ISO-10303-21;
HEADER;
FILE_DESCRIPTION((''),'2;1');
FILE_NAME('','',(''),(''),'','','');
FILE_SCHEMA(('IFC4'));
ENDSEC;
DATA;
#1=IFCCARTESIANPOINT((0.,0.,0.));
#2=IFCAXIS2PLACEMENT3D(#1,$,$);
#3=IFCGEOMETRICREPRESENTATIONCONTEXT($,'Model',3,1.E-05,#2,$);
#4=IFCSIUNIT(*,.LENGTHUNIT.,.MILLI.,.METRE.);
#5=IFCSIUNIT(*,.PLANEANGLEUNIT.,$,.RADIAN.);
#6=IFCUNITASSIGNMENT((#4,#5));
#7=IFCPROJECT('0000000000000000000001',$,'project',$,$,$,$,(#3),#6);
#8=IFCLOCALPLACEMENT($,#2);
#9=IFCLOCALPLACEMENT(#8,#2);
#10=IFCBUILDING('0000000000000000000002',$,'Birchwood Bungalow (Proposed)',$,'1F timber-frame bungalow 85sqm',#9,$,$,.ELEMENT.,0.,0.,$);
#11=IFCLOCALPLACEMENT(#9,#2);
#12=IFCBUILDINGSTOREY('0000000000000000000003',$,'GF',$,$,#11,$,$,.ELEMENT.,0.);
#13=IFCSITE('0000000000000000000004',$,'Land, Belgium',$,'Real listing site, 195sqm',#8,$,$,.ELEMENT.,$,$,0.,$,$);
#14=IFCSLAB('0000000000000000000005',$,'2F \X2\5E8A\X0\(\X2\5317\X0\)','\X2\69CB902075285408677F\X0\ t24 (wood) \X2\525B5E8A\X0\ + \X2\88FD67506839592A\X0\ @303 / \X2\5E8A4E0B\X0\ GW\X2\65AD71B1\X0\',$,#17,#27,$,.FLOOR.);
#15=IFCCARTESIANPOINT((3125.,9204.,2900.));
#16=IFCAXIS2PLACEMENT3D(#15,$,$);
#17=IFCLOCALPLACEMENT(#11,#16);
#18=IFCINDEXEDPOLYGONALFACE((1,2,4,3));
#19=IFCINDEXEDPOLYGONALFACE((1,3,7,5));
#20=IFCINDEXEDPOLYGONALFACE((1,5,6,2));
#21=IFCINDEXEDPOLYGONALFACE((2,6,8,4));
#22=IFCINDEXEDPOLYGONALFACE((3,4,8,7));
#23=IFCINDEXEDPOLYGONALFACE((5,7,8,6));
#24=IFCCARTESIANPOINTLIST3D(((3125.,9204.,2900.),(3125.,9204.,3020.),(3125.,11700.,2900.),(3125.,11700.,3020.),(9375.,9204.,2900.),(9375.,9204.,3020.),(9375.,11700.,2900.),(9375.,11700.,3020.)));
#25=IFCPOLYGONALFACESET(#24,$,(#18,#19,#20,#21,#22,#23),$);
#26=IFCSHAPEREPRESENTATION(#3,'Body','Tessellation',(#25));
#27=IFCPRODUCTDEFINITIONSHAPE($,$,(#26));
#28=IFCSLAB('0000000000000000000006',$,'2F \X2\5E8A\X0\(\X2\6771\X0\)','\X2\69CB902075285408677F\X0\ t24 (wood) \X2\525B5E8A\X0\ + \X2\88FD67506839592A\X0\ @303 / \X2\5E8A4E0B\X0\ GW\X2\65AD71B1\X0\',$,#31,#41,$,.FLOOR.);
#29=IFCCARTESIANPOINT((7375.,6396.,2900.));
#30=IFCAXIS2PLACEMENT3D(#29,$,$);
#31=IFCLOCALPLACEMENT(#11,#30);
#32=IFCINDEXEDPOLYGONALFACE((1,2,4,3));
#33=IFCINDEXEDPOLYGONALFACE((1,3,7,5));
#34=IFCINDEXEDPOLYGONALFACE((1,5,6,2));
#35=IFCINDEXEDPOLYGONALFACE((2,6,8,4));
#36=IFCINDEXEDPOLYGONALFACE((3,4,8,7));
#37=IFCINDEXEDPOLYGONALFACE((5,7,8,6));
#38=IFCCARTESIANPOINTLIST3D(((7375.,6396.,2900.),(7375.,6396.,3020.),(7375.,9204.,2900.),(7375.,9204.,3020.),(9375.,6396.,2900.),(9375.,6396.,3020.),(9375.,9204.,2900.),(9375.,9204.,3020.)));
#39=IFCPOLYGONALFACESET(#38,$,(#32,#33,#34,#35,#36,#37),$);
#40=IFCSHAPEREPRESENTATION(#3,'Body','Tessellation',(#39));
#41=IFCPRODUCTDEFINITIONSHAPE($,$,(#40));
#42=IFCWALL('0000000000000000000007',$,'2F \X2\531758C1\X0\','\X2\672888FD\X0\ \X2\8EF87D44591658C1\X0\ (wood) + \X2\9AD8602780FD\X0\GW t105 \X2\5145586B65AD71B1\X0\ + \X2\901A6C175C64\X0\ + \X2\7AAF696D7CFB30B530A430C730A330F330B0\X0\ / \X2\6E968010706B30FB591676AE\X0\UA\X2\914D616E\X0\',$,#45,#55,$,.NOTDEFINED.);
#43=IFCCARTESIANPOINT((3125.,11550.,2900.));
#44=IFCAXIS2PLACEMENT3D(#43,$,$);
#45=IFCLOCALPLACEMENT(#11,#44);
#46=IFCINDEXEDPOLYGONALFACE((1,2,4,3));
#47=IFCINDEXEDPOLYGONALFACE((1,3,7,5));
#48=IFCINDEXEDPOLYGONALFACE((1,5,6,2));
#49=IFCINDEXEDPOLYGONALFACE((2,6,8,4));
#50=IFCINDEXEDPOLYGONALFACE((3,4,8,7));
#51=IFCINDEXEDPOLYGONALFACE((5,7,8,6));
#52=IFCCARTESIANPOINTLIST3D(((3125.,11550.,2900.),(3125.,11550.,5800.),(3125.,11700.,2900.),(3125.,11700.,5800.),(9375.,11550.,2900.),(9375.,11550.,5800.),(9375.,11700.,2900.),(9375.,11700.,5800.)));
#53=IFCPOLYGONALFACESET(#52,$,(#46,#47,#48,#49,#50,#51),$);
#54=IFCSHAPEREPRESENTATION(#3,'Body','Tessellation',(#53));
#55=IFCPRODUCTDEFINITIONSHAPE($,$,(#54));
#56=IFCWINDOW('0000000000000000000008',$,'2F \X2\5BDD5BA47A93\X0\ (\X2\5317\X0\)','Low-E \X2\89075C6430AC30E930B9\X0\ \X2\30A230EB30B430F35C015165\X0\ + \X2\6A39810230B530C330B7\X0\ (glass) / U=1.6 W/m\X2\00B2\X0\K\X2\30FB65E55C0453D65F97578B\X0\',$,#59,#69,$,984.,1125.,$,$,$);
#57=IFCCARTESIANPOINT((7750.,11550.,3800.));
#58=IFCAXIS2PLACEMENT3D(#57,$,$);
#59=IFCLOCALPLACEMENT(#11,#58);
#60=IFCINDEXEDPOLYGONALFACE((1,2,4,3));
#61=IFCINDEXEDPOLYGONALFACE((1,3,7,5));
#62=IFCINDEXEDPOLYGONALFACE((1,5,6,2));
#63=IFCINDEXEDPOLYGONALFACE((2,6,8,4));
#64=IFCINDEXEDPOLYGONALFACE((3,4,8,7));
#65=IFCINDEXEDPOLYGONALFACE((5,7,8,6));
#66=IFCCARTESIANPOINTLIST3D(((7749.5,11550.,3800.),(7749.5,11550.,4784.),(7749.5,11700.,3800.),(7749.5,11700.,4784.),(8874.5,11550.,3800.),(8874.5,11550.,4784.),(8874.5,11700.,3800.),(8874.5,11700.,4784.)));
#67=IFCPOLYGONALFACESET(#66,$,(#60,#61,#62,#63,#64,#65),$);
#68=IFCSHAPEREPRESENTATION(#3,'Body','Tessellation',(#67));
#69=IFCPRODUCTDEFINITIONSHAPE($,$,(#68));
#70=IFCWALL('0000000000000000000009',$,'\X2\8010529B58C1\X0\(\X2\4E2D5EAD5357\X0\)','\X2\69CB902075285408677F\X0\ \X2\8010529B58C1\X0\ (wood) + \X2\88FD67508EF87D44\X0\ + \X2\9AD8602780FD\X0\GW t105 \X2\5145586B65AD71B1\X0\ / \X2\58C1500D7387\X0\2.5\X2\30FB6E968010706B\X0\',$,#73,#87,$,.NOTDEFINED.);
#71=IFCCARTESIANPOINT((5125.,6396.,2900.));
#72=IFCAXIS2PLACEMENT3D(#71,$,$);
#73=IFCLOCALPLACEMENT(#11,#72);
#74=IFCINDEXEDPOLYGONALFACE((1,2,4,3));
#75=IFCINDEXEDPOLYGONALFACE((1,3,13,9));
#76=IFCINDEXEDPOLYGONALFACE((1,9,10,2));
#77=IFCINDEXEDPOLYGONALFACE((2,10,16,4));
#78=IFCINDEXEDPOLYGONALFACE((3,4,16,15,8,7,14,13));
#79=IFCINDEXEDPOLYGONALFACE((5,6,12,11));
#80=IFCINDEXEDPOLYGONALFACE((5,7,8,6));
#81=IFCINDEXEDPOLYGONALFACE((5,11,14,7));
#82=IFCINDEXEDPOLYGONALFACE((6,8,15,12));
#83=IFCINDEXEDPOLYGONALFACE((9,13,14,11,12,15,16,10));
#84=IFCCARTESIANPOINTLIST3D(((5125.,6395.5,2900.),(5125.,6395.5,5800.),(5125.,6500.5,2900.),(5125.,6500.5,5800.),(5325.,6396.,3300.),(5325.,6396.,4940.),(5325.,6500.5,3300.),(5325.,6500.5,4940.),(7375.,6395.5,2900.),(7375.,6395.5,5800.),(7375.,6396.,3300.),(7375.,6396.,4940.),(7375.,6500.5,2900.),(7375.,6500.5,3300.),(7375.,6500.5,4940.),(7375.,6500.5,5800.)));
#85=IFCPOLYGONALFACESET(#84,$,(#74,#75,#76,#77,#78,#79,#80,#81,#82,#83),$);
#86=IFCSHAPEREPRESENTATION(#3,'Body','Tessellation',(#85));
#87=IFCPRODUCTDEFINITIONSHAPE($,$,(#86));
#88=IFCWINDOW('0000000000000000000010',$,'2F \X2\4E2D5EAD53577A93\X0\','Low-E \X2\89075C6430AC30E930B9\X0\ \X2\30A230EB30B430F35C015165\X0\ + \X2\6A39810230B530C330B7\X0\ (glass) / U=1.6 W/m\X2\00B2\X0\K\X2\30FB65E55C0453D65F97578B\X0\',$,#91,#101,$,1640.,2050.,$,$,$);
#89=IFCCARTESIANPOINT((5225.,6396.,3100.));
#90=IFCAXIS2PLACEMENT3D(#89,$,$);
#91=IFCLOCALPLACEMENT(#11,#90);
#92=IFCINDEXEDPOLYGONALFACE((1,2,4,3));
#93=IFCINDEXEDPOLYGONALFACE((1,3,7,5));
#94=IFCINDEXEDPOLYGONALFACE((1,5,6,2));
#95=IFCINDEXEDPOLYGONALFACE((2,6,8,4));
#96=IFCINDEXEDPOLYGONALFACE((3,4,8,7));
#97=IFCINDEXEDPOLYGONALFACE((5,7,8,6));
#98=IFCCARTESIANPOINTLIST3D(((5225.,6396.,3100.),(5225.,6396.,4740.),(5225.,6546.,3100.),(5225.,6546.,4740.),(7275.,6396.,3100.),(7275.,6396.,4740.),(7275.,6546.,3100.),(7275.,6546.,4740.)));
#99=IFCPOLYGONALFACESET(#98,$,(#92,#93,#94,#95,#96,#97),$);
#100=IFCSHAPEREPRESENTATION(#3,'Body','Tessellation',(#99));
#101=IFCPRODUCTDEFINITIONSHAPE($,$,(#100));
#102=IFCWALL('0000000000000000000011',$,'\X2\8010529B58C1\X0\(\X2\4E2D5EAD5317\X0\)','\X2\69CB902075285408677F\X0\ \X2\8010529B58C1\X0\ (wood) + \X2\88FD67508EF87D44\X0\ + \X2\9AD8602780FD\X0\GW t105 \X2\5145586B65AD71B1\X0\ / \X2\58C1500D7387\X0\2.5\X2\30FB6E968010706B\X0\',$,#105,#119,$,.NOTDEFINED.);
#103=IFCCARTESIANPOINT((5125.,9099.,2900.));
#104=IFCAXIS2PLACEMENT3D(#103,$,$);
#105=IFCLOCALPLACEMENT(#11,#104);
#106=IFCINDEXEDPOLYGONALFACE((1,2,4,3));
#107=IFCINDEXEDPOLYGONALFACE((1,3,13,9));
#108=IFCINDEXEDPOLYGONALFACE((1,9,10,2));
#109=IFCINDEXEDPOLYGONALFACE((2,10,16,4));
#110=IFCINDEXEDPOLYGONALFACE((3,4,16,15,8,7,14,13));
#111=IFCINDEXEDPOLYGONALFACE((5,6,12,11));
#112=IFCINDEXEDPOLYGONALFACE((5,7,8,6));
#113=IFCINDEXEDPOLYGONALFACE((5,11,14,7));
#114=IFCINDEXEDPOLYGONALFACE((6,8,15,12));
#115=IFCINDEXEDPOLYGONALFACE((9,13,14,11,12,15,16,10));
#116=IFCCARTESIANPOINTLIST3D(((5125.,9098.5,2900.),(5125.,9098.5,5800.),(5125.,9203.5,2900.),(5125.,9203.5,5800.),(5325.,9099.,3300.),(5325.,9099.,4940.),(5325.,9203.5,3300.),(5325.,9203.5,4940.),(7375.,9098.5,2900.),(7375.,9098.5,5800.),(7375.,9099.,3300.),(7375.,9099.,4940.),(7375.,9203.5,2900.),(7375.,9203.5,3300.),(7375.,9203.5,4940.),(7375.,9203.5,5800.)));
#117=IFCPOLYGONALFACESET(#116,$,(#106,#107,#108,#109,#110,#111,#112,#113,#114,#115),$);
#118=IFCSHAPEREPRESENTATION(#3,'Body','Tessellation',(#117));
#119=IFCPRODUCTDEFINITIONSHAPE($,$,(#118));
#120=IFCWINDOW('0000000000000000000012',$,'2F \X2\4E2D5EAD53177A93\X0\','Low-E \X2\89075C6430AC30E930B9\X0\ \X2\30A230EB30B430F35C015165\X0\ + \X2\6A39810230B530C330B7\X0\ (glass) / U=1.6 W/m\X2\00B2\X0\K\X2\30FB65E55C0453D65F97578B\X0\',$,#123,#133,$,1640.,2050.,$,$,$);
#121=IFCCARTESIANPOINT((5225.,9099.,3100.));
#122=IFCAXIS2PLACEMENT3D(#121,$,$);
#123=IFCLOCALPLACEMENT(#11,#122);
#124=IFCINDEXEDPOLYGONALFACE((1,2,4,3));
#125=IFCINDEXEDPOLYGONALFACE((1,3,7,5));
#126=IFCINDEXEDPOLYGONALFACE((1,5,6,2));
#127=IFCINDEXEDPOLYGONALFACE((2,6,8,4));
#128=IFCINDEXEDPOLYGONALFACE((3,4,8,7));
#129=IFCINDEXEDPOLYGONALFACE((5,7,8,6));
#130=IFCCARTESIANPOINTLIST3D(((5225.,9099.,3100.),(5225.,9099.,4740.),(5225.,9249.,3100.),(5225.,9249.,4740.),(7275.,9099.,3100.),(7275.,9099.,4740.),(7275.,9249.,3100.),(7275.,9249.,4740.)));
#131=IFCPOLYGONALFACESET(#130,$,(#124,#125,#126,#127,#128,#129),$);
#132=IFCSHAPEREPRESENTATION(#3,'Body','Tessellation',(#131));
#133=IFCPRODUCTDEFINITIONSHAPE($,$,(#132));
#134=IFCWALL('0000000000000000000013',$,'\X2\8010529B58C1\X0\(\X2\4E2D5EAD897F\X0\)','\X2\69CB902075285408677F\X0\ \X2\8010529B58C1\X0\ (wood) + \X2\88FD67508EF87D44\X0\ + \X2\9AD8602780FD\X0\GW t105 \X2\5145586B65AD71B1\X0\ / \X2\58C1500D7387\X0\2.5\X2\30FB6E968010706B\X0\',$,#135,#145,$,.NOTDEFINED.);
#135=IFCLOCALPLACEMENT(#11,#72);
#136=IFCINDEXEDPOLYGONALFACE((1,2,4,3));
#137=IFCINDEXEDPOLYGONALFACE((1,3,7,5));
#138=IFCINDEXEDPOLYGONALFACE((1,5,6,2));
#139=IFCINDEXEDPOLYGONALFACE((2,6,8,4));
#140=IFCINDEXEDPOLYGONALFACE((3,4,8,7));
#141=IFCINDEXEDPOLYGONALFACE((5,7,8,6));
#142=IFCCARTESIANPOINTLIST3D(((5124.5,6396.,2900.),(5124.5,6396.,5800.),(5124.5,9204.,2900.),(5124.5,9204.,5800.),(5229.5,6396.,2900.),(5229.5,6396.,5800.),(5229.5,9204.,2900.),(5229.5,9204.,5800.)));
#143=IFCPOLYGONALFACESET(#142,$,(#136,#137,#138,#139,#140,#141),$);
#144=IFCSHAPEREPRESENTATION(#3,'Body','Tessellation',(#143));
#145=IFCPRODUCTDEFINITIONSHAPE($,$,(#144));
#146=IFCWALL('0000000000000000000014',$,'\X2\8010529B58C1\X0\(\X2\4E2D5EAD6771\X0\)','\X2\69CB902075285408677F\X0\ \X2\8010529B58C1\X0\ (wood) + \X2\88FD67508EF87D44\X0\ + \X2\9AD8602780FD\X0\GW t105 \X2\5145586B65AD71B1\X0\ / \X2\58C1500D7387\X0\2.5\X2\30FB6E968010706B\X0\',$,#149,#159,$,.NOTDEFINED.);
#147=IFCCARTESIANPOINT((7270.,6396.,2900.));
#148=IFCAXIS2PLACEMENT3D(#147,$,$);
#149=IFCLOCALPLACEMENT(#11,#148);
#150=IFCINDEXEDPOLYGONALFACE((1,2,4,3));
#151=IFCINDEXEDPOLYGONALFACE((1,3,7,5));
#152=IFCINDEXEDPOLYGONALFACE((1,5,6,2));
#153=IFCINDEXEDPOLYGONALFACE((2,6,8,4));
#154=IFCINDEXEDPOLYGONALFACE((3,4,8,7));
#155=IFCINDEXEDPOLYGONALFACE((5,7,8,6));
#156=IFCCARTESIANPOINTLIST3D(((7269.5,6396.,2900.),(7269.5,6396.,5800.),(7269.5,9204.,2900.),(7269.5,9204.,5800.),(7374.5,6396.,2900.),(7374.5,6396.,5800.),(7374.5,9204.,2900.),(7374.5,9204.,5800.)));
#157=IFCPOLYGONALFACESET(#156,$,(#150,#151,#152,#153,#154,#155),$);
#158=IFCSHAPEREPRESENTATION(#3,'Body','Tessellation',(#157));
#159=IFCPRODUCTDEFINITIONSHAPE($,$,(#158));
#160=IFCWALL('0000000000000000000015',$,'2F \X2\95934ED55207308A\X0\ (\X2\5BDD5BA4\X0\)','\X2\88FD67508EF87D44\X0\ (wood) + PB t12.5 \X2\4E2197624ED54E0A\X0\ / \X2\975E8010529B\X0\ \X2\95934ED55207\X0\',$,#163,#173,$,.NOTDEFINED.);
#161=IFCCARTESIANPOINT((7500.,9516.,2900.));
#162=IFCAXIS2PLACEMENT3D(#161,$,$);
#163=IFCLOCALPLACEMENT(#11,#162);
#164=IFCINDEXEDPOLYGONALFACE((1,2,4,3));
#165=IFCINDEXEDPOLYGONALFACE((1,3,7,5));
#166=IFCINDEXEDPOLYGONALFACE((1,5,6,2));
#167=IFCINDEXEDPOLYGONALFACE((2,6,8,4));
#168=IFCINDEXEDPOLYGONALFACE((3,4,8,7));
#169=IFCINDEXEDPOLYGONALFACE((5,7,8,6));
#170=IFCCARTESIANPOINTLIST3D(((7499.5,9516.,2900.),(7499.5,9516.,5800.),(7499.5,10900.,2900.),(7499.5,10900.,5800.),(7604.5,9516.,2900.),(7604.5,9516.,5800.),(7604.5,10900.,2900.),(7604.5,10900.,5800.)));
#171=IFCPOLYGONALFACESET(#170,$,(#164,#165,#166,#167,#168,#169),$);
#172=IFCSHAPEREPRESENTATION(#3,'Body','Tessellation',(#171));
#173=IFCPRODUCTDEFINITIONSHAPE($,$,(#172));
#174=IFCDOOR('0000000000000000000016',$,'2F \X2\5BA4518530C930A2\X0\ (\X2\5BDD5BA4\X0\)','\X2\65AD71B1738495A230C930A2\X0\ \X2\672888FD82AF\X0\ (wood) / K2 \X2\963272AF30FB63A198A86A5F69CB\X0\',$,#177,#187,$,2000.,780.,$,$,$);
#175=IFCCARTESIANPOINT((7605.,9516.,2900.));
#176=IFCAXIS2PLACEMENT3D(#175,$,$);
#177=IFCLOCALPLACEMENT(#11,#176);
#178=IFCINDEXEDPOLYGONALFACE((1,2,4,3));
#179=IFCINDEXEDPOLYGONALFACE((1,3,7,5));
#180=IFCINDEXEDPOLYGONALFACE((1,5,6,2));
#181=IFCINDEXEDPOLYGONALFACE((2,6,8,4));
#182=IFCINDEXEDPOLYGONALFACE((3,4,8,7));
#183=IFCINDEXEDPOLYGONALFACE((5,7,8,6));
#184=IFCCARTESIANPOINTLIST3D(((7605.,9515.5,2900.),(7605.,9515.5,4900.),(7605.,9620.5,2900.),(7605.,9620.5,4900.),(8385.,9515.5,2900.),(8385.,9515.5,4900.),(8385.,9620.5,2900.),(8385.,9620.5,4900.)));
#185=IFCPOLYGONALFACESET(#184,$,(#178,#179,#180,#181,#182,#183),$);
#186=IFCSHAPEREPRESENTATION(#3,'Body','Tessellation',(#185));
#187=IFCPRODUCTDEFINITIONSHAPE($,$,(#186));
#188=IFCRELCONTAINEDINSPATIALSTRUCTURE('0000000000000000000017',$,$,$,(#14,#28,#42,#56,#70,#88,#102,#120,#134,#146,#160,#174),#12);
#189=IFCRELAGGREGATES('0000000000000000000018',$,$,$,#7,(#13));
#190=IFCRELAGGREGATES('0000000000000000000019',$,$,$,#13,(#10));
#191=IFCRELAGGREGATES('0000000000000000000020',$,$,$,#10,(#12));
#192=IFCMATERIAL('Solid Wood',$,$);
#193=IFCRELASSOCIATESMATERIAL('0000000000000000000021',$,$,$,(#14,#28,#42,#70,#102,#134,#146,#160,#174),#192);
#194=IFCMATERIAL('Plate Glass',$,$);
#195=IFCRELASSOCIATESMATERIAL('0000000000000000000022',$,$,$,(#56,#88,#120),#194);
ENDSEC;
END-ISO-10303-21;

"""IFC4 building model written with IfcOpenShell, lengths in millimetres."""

from ifc_helpers import new_model, si_unit, frame, frame_2d, origin, place, context, project, spatial, rectangle, extrude, material, element, fill, save


model = new_model("IFC4")

# Units and contexts
model_context = context("Model", 3, precision=1e-05, world=origin())
ifc_project = project(units=[si_unit("LENGTHUNIT", "METRE", prefix="MILLI"), si_unit("PLANEANGLEUNIT", "RADIAN")], contexts=[model_context])

# Site, building, storey
site_placement = place(None, origin())
site = spatial("IfcSite", under=ifc_project, at=site_placement, Name="Land, Belgium", ObjectType="Real listing site, 195sqm", CompositionType="ELEMENT", RefElevation=0.0)
building_placement = place(site_placement, origin())
building = spatial("IfcBuilding", under=site, at=building_placement, Name="Birchwood Bungalow (Proposed)", ObjectType="1F timber-frame bungalow 85sqm", CompositionType="ELEMENT", ElevationOfRefHeight=0.0, ElevationOfTerrain=0.0)
storey_placement = place(building_placement, origin())
storey = spatial("IfcBuildingStorey", under=building, at=storey_placement, Name="GF", CompositionType="ELEMENT", Elevation=0.0)

# Slabs
ifc_material_1 = material(Name="Solid Wood")
slab_1_placement = place(storey_placement, frame((3125.0, 9204.0, 2900.0)))
element("IfcSlab", 1, at=slab_1_placement, inside=storey, material=ifc_material_1, Name="2F 床(北)", Description="構造用合板 t24 (wood) 剛床 + 製材根太 @303 / 床下 GW断熱", PredefinedType="FLOOR", context=model_context, shape_type="SweptSolid", body=[
    extrude(rectangle(XDim=6250.0, YDim=2496.0, at=frame_2d((3125.0, 1248.0))), frame((3125.0, 9204.0, 2900.0)), (0.0, 0.0, 1.0), 120.0),
])
slab_2_placement = place(storey_placement, frame((7375.0, 6396.0, 2900.0)))
element("IfcSlab", 2, at=slab_2_placement, inside=storey, material=ifc_material_1, Name="2F 床(東)", Description="構造用合板 t24 (wood) 剛床 + 製材根太 @303 / 床下 GW断熱", PredefinedType="FLOOR", context=model_context, shape_type="SweptSolid", body=[
    extrude(rectangle(XDim=2000.0, YDim=2808.0, at=frame_2d((1000.0, 1404.0))), frame((7375.0, 6396.0, 2900.0)), (0.0, 0.0, 1.0), 120.0),
])

# Walls, openings, windows
wall_1_placement = place(storey_placement, frame((3125.0, 11550.0, 2900.0)))
wall_1 = element("IfcWall", 3, at=wall_1_placement, inside=storey, material=ifc_material_1, Name="2F 北壁", Description="木製 軸組外壁 (wood) + 高性能GW t105 充填断熱 + 通気層 + 窯業系サイディング / 準耐火・外皮UA配慮", PredefinedType="NOTDEFINED", context=model_context, shape_type="SweptSolid", body=[
    extrude(rectangle(XDim=6250.0, YDim=150.0, at=frame_2d((3125.0, 75.0))), frame((3125.0, 11550.0, 2900.0)), (0.0, 0.0, 1.0), 2900.0),
])
opening_1_placement = place(storey_placement, frame((7750.0, 11550.0, 3800.0)))
opening_1 = element("IfcOpeningElement", 4, at=opening_1_placement, cuts=wall_1, PredefinedType="NOTDEFINED", context=model_context, shape_type="SweptSolid", body=[
    extrude(rectangle(XDim=1125.0, YDim=150.0, at=frame_2d((562.0, 75.0))), frame((7750.0, 11550.0, 3800.0)), (0.0, 0.0, 1.0), 984.0),
])
ifc_material_2 = material(Name="Plate Glass")
window_1_placement = place(storey_placement, frame((7750.0, 11550.0, 3800.0)))
window_1 = element("IfcWindow", 5, at=window_1_placement, inside=storey, material=ifc_material_2, Name="2F 寝室窓 (北)", Description="Low-E 複層ガラス アルゴン封入 + 樹脂サッシ (glass) / U=1.6 W/m²K・日射取得型", OverallHeight=984.0, OverallWidth=1125.0, context=model_context, shape_type="SweptSolid", body=[
    extrude(rectangle(XDim=1125.0, YDim=150.0, at=frame_2d((562.0, 75.0))), frame((7750.0, 11550.0, 3800.0)), (0.0, 0.0, 1.0), 984.0),
])
fill(opening_1, window_1)
wall_2_placement = place(storey_placement, frame((5125.0, 6396.0, 2900.0)))
wall_2 = element("IfcWall", 6, at=wall_2_placement, inside=storey, material=ifc_material_1, Name="耐力壁(中庭南)", Description="構造用合板 耐力壁 (wood) + 製材軸組 + 高性能GW t105 充填断熱 / 壁倍率2.5・準耐火", PredefinedType="NOTDEFINED", context=model_context, shape_type="SweptSolid", body=[
    extrude(rectangle(XDim=2250.0, YDim=105.0, at=frame_2d((1125.0, 52.0))), frame((5125.0, 6396.0, 2900.0)), (0.0, 0.0, 1.0), 2900.0),
])
opening_2_placement = place(storey_placement, frame((5225.0, 6396.0, 3100.0)))
opening_2 = element("IfcOpeningElement", 7, at=opening_2_placement, cuts=wall_2, PredefinedType="NOTDEFINED", context=model_context, shape_type="SweptSolid", body=[
    extrude(rectangle(XDim=2050.0, YDim=150.0, at=frame_2d((1025.0, 75.0))), frame((5225.0, 6396.0, 3100.0)), (0.0, 0.0, 1.0), 1640.0),
])
window_2_placement = place(storey_placement, frame((5225.0, 6396.0, 3100.0)))
window_2 = element("IfcWindow", 8, at=window_2_placement, inside=storey, material=ifc_material_2, Name="2F 中庭南窓", Description="Low-E 複層ガラス アルゴン封入 + 樹脂サッシ (glass) / U=1.6 W/m²K・日射取得型", OverallHeight=1640.0, OverallWidth=2050.0, context=model_context, shape_type="SweptSolid", body=[
    extrude(rectangle(XDim=2050.0, YDim=150.0, at=frame_2d((1025.0, 75.0))), frame((5225.0, 6396.0, 3100.0)), (0.0, 0.0, 1.0), 1640.0),
])
fill(opening_2, window_2)
wall_3_placement = place(storey_placement, frame((5125.0, 9099.0, 2900.0)))
wall_3 = element("IfcWall", 9, at=wall_3_placement, inside=storey, material=ifc_material_1, Name="耐力壁(中庭北)", Description="構造用合板 耐力壁 (wood) + 製材軸組 + 高性能GW t105 充填断熱 / 壁倍率2.5・準耐火", PredefinedType="NOTDEFINED", context=model_context, shape_type="SweptSolid", body=[
    extrude(rectangle(XDim=2250.0, YDim=105.0, at=frame_2d((1125.0, 52.0))), frame((5125.0, 9099.0, 2900.0)), (0.0, 0.0, 1.0), 2900.0),
])
opening_3_placement = place(storey_placement, frame((5225.0, 9099.0, 3100.0)))
opening_3 = element("IfcOpeningElement", 10, at=opening_3_placement, cuts=wall_3, PredefinedType="NOTDEFINED", context=model_context, shape_type="SweptSolid", body=[
    extrude(rectangle(XDim=2050.0, YDim=150.0, at=frame_2d((1025.0, 75.0))), frame((5225.0, 9099.0, 3100.0)), (0.0, 0.0, 1.0), 1640.0),
])
window_3_placement = place(storey_placement, frame((5225.0, 9099.0, 3100.0)))
window_3 = element("IfcWindow", 11, at=window_3_placement, inside=storey, material=ifc_material_2, Name="2F 中庭北窓", Description="Low-E 複層ガラス アルゴン封入 + 樹脂サッシ (glass) / U=1.6 W/m²K・日射取得型", OverallHeight=1640.0, OverallWidth=2050.0, context=model_context, shape_type="SweptSolid", body=[
    extrude(rectangle(XDim=2050.0, YDim=150.0, at=frame_2d((1025.0, 75.0))), frame((5225.0, 9099.0, 3100.0)), (0.0, 0.0, 1.0), 1640.0),
])
fill(opening_3, window_3)

# Walls
wall_4_placement = place(storey_placement, frame((5125.0, 6396.0, 2900.0)))
element("IfcWall", 12, at=wall_4_placement, inside=storey, material=ifc_material_1, Name="耐力壁(中庭西)", Description="構造用合板 耐力壁 (wood) + 製材軸組 + 高性能GW t105 充填断熱 / 壁倍率2.5・準耐火", PredefinedType="NOTDEFINED", context=model_context, shape_type="SweptSolid", body=[
    extrude(rectangle(XDim=105.0, YDim=2808.0, at=frame_2d((52.0, 1404.0))), frame((5125.0, 6396.0, 2900.0)), (0.0, 0.0, 1.0), 2900.0),
])
wall_5_placement = place(storey_placement, frame((7270.0, 6396.0, 2900.0)))
element("IfcWall", 13, at=wall_5_placement, inside=storey, material=ifc_material_1, Name="耐力壁(中庭東)", Description="構造用合板 耐力壁 (wood) + 製材軸組 + 高性能GW t105 充填断熱 / 壁倍率2.5・準耐火", PredefinedType="NOTDEFINED", context=model_context, shape_type="SweptSolid", body=[
    extrude(rectangle(XDim=105.0, YDim=2808.0, at=frame_2d((52.0, 1404.0))), frame((7270.0, 6396.0, 2900.0)), (0.0, 0.0, 1.0), 2900.0),
])
wall_6_placement = place(storey_placement, frame((7500.0, 9516.0, 2900.0)))
element("IfcWall", 14, at=wall_6_placement, inside=storey, material=ifc_material_1, Name="2F 間仕切り (寝室)", Description="製材軸組 (wood) + PB t12.5 両面仕上 / 非耐力 間仕切", PredefinedType="NOTDEFINED", context=model_context, shape_type="SweptSolid", body=[
    extrude(rectangle(XDim=105.0, YDim=1384.0, at=frame_2d((52.0, 692.0))), frame((7500.0, 9516.0, 2900.0)), (0.0, 0.0, 1.0), 2900.0),
])

# Door
door_placement = place(storey_placement, frame((7605.0, 9516.0, 2900.0)))
element("IfcDoor", 15, at=door_placement, inside=storey, material=ifc_material_1, Name="2F 室内ドア (寝室)", Description="断熱玄関ドア 木製芯 (wood) / K2 防犯・採風機構", OverallHeight=2000.0, OverallWidth=780.0, context=model_context, shape_type="SweptSolid", body=[
    extrude(rectangle(XDim=780.0, YDim=105.0, at=frame_2d((390.0, 52.0))), frame((7605.0, 9516.0, 2900.0)), (0.0, 0.0, 1.0), 2000.0),
])

save(model, "model.ifc")
